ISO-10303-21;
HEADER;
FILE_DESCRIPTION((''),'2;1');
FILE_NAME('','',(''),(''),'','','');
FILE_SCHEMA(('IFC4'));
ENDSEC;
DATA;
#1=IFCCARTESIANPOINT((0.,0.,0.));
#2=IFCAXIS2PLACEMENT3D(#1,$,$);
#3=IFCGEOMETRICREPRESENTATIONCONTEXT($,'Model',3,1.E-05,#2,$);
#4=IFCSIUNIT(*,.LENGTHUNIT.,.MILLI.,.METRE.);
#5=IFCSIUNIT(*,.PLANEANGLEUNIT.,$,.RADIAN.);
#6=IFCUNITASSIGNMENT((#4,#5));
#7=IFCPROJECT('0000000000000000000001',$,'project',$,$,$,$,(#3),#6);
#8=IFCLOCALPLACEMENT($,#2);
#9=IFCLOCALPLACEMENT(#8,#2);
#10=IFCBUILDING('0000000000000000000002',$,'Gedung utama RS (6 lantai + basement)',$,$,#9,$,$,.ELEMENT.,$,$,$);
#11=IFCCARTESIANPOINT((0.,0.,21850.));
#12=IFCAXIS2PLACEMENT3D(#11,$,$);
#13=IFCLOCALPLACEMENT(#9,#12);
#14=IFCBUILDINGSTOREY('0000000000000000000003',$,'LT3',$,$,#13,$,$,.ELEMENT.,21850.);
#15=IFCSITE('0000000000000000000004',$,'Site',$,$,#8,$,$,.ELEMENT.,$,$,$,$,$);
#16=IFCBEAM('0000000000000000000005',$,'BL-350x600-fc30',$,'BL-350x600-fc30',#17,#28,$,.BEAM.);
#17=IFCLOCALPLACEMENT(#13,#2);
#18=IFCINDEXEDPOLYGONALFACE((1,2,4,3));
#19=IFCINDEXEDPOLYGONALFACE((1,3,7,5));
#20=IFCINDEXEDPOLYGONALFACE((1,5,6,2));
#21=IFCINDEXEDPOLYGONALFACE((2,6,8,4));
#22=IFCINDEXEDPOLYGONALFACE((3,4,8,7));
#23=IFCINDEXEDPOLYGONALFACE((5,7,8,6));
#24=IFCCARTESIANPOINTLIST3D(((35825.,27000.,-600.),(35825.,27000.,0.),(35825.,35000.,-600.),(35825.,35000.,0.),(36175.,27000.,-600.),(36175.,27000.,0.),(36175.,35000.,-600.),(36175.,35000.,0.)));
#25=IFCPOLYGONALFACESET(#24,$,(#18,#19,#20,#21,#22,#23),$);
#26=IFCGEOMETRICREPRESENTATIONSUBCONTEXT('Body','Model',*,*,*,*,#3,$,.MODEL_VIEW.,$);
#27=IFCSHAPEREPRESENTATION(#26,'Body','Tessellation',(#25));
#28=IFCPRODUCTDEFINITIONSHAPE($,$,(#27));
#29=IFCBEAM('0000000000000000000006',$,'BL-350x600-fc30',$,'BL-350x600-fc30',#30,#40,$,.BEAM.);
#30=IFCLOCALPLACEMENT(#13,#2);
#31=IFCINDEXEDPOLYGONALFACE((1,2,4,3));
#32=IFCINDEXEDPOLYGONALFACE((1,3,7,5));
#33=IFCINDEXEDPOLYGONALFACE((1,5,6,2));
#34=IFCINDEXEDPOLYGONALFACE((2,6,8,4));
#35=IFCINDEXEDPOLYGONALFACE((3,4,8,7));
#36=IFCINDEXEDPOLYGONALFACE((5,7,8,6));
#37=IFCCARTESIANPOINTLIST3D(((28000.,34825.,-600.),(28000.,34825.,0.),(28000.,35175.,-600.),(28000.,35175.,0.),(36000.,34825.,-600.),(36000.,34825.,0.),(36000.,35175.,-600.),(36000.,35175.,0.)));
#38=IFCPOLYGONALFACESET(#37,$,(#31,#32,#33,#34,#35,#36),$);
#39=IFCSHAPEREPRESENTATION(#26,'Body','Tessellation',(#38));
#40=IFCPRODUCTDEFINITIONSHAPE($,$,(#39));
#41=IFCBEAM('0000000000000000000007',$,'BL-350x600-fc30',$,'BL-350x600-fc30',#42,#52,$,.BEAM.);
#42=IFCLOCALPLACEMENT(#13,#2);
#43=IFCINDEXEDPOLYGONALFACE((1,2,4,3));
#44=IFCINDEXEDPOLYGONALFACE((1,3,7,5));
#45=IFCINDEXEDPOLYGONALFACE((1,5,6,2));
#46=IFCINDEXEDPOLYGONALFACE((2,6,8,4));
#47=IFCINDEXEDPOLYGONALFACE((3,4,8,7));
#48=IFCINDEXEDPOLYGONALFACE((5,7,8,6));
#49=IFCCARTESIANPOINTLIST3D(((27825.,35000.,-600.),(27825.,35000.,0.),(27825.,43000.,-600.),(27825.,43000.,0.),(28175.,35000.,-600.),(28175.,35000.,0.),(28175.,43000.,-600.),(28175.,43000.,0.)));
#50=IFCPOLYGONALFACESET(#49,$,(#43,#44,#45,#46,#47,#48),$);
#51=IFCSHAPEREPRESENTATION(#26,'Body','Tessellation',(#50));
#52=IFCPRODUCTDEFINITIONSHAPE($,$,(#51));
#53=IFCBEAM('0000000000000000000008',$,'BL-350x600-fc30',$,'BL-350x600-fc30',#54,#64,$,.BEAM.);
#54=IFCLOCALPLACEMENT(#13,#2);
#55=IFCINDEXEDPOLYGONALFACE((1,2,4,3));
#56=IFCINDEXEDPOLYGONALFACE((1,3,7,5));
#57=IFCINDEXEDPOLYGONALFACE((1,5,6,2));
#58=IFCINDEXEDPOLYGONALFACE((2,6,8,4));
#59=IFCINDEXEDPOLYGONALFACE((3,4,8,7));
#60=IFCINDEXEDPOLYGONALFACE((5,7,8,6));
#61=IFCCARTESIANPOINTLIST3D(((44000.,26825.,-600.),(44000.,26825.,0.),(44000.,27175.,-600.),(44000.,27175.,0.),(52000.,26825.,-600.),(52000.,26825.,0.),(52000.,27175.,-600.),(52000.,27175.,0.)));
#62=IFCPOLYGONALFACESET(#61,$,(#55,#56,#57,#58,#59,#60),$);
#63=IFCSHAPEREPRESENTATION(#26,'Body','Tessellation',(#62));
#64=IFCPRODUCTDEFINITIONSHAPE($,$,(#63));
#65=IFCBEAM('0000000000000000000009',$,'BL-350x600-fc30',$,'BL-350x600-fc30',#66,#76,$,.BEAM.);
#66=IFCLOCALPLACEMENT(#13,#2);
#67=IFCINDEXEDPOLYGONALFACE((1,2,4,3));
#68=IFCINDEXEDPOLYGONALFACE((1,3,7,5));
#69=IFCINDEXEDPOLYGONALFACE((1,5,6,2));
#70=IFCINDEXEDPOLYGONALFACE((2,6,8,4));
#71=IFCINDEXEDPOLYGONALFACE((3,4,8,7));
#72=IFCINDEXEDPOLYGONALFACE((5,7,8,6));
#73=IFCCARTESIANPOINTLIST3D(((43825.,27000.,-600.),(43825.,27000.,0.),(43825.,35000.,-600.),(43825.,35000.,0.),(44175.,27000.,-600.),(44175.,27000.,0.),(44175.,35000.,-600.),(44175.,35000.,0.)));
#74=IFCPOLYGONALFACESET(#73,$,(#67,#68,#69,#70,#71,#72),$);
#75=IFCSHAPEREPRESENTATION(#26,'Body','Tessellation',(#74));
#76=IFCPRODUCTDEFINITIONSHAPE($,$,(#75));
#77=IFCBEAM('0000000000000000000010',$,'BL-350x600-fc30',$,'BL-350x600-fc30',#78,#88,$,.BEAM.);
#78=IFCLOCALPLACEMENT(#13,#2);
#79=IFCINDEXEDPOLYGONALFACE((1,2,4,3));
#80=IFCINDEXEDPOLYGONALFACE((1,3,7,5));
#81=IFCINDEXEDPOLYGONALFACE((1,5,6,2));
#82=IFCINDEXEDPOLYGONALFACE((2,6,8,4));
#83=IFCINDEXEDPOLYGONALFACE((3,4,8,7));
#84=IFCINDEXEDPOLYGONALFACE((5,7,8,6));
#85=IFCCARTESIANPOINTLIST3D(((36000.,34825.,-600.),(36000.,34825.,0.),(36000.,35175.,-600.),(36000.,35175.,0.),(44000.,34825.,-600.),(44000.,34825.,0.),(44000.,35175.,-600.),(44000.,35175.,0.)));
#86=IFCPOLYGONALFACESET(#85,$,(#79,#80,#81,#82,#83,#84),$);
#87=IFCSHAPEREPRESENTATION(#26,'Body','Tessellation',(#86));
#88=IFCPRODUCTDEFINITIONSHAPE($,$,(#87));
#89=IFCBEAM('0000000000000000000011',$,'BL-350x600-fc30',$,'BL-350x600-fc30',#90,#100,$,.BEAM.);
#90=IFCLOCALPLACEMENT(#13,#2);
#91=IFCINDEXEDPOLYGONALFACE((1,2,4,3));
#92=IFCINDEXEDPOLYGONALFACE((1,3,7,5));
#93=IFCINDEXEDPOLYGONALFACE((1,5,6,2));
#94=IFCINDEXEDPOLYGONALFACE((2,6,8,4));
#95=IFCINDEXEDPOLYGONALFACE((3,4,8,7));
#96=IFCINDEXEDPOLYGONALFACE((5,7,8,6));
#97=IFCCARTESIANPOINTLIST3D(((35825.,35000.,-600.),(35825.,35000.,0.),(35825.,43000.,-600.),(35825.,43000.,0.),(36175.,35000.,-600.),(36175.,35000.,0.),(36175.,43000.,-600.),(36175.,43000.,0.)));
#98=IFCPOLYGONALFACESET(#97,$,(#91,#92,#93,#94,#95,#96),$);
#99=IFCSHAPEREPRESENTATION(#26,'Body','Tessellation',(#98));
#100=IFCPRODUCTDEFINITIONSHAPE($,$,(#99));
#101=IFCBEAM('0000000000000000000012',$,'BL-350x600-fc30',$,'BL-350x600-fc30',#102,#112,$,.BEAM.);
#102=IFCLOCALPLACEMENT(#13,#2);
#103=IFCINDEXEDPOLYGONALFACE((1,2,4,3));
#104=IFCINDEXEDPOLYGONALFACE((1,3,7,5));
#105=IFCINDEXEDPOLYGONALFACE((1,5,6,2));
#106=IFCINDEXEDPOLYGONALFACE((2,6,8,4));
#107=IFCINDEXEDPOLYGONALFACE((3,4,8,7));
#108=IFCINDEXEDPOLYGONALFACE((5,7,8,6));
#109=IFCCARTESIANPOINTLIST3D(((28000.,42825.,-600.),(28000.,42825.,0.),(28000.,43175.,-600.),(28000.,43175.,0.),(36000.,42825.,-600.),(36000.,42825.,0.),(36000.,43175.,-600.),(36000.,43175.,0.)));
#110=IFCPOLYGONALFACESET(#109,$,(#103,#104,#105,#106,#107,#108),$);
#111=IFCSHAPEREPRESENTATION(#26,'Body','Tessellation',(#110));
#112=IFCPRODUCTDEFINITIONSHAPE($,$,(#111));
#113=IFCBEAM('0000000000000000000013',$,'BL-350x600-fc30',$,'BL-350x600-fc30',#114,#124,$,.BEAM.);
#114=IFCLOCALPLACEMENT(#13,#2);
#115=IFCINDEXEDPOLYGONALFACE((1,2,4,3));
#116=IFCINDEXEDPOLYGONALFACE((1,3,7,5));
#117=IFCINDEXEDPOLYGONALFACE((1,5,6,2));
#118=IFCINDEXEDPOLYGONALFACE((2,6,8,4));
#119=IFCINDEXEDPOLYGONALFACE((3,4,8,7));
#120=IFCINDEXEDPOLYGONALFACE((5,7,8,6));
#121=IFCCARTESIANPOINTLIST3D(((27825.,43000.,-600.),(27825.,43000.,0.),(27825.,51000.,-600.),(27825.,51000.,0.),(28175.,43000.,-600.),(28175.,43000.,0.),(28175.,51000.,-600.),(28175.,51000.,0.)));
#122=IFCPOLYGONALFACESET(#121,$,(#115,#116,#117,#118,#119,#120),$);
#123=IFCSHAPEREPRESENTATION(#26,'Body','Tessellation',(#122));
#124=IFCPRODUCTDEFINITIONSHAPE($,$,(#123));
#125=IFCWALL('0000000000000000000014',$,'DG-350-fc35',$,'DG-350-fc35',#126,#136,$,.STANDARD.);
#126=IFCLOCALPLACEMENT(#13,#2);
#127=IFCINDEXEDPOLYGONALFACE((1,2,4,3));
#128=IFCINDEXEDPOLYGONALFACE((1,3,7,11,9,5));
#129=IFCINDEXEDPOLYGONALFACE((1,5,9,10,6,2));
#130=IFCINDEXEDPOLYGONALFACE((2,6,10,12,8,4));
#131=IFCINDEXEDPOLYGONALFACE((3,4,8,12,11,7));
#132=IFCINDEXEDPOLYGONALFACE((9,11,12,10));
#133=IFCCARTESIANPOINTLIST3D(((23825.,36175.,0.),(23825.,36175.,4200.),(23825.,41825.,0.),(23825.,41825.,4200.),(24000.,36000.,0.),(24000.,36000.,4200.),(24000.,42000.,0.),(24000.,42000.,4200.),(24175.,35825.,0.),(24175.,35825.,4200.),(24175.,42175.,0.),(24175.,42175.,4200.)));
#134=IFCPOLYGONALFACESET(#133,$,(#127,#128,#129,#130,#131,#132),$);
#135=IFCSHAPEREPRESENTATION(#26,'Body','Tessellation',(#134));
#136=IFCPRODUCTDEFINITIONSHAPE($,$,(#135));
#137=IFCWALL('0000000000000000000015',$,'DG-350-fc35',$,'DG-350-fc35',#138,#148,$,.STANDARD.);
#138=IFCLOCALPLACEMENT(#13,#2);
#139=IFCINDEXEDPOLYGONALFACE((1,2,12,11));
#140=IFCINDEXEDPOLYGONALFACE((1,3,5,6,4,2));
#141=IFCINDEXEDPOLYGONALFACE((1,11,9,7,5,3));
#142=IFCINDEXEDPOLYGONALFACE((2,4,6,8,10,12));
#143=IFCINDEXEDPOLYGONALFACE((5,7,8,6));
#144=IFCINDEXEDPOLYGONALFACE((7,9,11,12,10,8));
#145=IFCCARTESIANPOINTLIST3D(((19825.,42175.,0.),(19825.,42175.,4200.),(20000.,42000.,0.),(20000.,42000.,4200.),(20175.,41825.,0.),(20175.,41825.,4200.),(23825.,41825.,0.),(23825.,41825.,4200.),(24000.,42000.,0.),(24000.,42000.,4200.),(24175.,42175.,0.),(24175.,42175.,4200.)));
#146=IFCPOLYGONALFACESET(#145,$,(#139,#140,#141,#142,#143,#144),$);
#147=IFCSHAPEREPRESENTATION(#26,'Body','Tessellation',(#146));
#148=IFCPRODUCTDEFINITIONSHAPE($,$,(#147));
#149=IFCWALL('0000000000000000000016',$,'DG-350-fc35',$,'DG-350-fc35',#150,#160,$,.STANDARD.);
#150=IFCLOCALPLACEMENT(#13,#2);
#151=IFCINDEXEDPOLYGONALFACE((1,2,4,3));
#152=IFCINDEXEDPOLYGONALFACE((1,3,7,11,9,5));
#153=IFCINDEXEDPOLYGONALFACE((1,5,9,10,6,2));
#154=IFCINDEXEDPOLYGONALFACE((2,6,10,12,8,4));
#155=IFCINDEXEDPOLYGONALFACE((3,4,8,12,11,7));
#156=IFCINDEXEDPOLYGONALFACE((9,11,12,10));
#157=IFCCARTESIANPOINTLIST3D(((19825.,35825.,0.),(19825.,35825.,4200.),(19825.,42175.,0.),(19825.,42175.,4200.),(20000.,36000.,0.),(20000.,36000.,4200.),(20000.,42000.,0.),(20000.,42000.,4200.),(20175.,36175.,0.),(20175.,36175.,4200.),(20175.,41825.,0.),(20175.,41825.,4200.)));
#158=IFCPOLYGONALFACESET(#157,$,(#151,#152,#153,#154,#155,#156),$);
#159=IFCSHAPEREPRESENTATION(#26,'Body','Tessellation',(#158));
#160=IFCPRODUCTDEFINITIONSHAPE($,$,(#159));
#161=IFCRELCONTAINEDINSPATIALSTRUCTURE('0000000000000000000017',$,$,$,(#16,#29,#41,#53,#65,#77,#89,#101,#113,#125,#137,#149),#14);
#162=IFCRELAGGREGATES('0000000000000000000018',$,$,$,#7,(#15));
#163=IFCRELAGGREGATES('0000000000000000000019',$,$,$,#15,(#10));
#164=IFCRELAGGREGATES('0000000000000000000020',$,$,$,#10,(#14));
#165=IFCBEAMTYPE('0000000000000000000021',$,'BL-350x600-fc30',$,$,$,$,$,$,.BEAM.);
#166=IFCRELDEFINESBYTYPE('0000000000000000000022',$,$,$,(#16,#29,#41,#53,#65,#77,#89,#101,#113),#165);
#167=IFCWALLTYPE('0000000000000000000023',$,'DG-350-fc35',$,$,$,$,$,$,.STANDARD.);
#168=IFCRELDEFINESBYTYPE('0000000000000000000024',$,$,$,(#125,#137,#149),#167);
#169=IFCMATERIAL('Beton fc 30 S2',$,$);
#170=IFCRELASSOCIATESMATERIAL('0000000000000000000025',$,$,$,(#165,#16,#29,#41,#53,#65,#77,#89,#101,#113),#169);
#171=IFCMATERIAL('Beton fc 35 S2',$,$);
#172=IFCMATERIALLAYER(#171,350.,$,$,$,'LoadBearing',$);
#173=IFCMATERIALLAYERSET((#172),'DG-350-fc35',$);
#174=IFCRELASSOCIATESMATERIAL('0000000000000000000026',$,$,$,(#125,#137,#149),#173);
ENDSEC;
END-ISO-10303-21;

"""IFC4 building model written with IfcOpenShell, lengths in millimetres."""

from ifc_helpers import new_model, si_unit, frame, origin, origin_2d, place, context, subcontext, project, spatial, polyline, rectangle, outline, extrude, material, layer, layer_set, layer_usage, material_profile, profile_set, profile_usage, type_object, element, save


model = new_model("IFC4")

# Units and contexts
model_context = context("Model", 3, precision=1e-05, world=origin())
body_context = subcontext(model_context, "Body", "Model", "MODEL_VIEW")
ifc_project = project(units=[si_unit("LENGTHUNIT", "METRE", prefix="MILLI"), si_unit("PLANEANGLEUNIT", "RADIAN")], contexts=[model_context])

# Site, building, storey
site_placement = place(None, origin())
site = spatial("IfcSite", under=ifc_project, at=site_placement, Name="Site", CompositionType="ELEMENT")
building_placement = place(site_placement, origin())
building = spatial("IfcBuilding", under=site, at=building_placement, Name="Gedung utama RS (6 lantai + basement)", CompositionType="ELEMENT")
storey_placement = place(building_placement, frame((0.0, 0.0, 21850.0)))
storey = spatial("IfcBuildingStorey", under=building, at=storey_placement, Name="LT3", CompositionType="ELEMENT", Elevation=21850.0)

# Beams
ifc_material_1 = material(Name="Beton fc 30 S2")
ifc_material_profile_1 = material_profile(ifc_material_1, rectangle(XDim=350.0, YDim=600.0, at=origin_2d()), Name="BL-350x600-fc30")
ifc_profile_set_1 = profile_set([ifc_material_profile_1], Name="BL-350x600-fc30")
ifc_profile_usage_1 = profile_usage(ifc_profile_set_1, cardinal=8)
beam_type = type_object("IfcBeamType", Name="BL-350x600-fc30", PredefinedType="BEAM", material=ifc_profile_set_1)
beam_1_placement = place(storey_placement, frame((36000.0, 27000.0, -300.0)))
element("IfcBeam", 1, at=beam_1_placement, inside=storey, type_object=beam_type, material=ifc_profile_usage_1, Name="BL-350x600-fc30", ObjectType="BL-350x600-fc30", PredefinedType="BEAM", context=body_context, shape_type="SweptSolid", body=[
    extrude(rectangle(XDim=350.0, YDim=600.0, at=origin_2d()), frame((0.0, 0.0, 0.0), z_axis=(0.0, 1.0, 0.0), x_axis=(-1.0, 0.0, 0.0)), (0.0, 0.0, 1.0), 8000.0),
])
beam_2_placement = place(storey_placement, frame((28000.0, 35000.0, -300.0)))
element("IfcBeam", 2, at=beam_2_placement, inside=storey, type_object=beam_type, material=ifc_profile_usage_1, Name="BL-350x600-fc30", ObjectType="BL-350x600-fc30", PredefinedType="BEAM", context=body_context, shape_type="SweptSolid", body=[
    extrude(rectangle(XDim=350.0, YDim=600.0, at=origin_2d()), frame((0.0, 0.0, 0.0), z_axis=(1.0, 0.0, 0.0), x_axis=(0.0, 1.0, 0.0)), (0.0, 0.0, 1.0), 8000.0),
])
beam_3_placement = place(storey_placement, frame((28000.0, 35000.0, -300.0)))
element("IfcBeam", 3, at=beam_3_placement, inside=storey, type_object=beam_type, material=ifc_profile_usage_1, Name="BL-350x600-fc30", ObjectType="BL-350x600-fc30", PredefinedType="BEAM", context=body_context, shape_type="SweptSolid", body=[
    extrude(rectangle(XDim=350.0, YDim=600.0, at=origin_2d()), frame((0.0, 0.0, 0.0), z_axis=(0.0, 1.0, 0.0), x_axis=(-1.0, 0.0, 0.0)), (0.0, 0.0, 1.0), 8000.0),
])
beam_4_placement = place(storey_placement, frame((44000.0, 27000.0, -300.0)))
element("IfcBeam", 4, at=beam_4_placement, inside=storey, type_object=beam_type, material=ifc_profile_usage_1, Name="BL-350x600-fc30", ObjectType="BL-350x600-fc30", PredefinedType="BEAM", context=body_context, shape_type="SweptSolid", body=[
    extrude(rectangle(XDim=350.0, YDim=600.0, at=origin_2d()), frame((0.0, 0.0, 0.0), z_axis=(1.0, 0.0, 0.0), x_axis=(0.0, 1.0, 0.0)), (0.0, 0.0, 1.0), 8000.0),
])
beam_5_placement = place(storey_placement, frame((44000.0, 27000.0, -300.0)))
element("IfcBeam", 5, at=beam_5_placement, inside=storey, type_object=beam_type, material=ifc_profile_usage_1, Name="BL-350x600-fc30", ObjectType="BL-350x600-fc30", PredefinedType="BEAM", context=body_context, shape_type="SweptSolid", body=[
    extrude(rectangle(XDim=350.0, YDim=600.0, at=origin_2d()), frame((0.0, 0.0, 0.0), z_axis=(0.0, 1.0, 0.0), x_axis=(-1.0, 0.0, 0.0)), (0.0, 0.0, 1.0), 8000.0),
])
beam_6_placement = place(storey_placement, frame((36000.0, 35000.0, -300.0)))
element("IfcBeam", 6, at=beam_6_placement, inside=storey, type_object=beam_type, material=ifc_profile_usage_1, Name="BL-350x600-fc30", ObjectType="BL-350x600-fc30", PredefinedType="BEAM", context=body_context, shape_type="SweptSolid", body=[
    extrude(rectangle(XDim=350.0, YDim=600.0, at=origin_2d()), frame((0.0, 0.0, 0.0), z_axis=(1.0, 0.0, 0.0), x_axis=(0.0, 1.0, 0.0)), (0.0, 0.0, 1.0), 8000.0),
])
beam_7_placement = place(storey_placement, frame((36000.0, 35000.0, -300.0)))
element("IfcBeam", 7, at=beam_7_placement, inside=storey, type_object=beam_type, material=ifc_profile_usage_1, Name="BL-350x600-fc30", ObjectType="BL-350x600-fc30", PredefinedType="BEAM", context=body_context, shape_type="SweptSolid", body=[
    extrude(rectangle(XDim=350.0, YDim=600.0, at=origin_2d()), frame((0.0, 0.0, 0.0), z_axis=(0.0, 1.0, 0.0), x_axis=(-1.0, 0.0, 0.0)), (0.0, 0.0, 1.0), 8000.0),
])
beam_8_placement = place(storey_placement, frame((28000.0, 43000.0, -300.0)))
element("IfcBeam", 8, at=beam_8_placement, inside=storey, type_object=beam_type, material=ifc_profile_usage_1, Name="BL-350x600-fc30", ObjectType="BL-350x600-fc30", PredefinedType="BEAM", context=body_context, shape_type="SweptSolid", body=[
    extrude(rectangle(XDim=350.0, YDim=600.0, at=origin_2d()), frame((0.0, 0.0, 0.0), z_axis=(1.0, 0.0, 0.0), x_axis=(0.0, 1.0, 0.0)), (0.0, 0.0, 1.0), 8000.0),
])
beam_9_placement = place(storey_placement, frame((28000.0, 43000.0, -300.0)))
element("IfcBeam", 9, at=beam_9_placement, inside=storey, type_object=beam_type, material=ifc_profile_usage_1, Name="BL-350x600-fc30", ObjectType="BL-350x600-fc30", PredefinedType="BEAM", context=body_context, shape_type="SweptSolid", body=[
    extrude(rectangle(XDim=350.0, YDim=600.0, at=origin_2d()), frame((0.0, 0.0, 0.0), z_axis=(0.0, 1.0, 0.0), x_axis=(-1.0, 0.0, 0.0)), (0.0, 0.0, 1.0), 8000.0),
])

# Walls
ifc_material_2 = material(Name="Beton fc 35 S2")
ifc_layer = layer(ifc_material_2, 350.0, Category="LoadBearing")
ifc_layer_set = layer_set([ifc_layer], Name="DG-350-fc35")
ifc_layer_usage = layer_usage(ifc_layer_set, "AXIS2", "NEGATIVE", 175.0)
wall_type = type_object("IfcWallType", Name="DG-350-fc35", PredefinedType="STANDARD")
wall_1_placement = place(storey_placement, frame((24000.0, 36000.0, 0.0), z_axis=(0.0, 0.0, 1.0), x_axis=(0.0, 1.0, 0.0)))
element("IfcWall", 10, at=wall_1_placement, inside=storey, type_object=wall_type, material=ifc_layer_usage, Name="DG-350-fc35", ObjectType="DG-350-fc35", PredefinedType="STANDARD", context=body_context, shape_type="SweptSolid", body=[
    extrude(outline(polyline([(-175.0, -175.0), (0.0, 0.0), (175.0, 175.0), (5825.0, 175.0), (6000.0, 0.0), (6175.0, -175.0), (-175.0, -175.0)])), origin(), (0.0, 0.0, 1.0), 4200.0),
])
wall_2_placement = place(storey_placement, frame((24000.0, 42000.0, 0.0), z_axis=(0.0, 0.0, 1.0), x_axis=(-1.0, 0.0, 0.0)))
element("IfcWall", 11, at=wall_2_placement, inside=storey, type_object=wall_type, material=ifc_layer_usage, Name="DG-350-fc35", ObjectType="DG-350-fc35", PredefinedType="STANDARD", context=body_context, shape_type="SweptSolid", body=[
    extrude(outline(polyline([(-175.0, -175.0), (0.0, 0.0), (175.0, 175.0), (3825.0, 175.0), (4000.0, 0.0), (4175.0, -175.0), (-175.0, -175.0)])), origin(), (0.0, 0.0, 1.0), 4200.0),
])
wall_3_placement = place(storey_placement, frame((20000.0, 42000.0, 0.0), z_axis=(0.0, 0.0, 1.0), x_axis=(0.0, -1.0, 0.0)))
element("IfcWall", 12, at=wall_3_placement, inside=storey, type_object=wall_type, material=ifc_layer_usage, Name="DG-350-fc35", ObjectType="DG-350-fc35", PredefinedType="STANDARD", context=body_context, shape_type="SweptSolid", body=[
    extrude(outline(polyline([(-175.0, -175.0), (0.0, 0.0), (175.0, 175.0), (5825.0, 175.0), (6000.0, 0.0), (6175.0, -175.0), (-175.0, -175.0)])), origin(), (0.0, 0.0, 1.0), 4200.0),
])

save(model, "model.ifc")
